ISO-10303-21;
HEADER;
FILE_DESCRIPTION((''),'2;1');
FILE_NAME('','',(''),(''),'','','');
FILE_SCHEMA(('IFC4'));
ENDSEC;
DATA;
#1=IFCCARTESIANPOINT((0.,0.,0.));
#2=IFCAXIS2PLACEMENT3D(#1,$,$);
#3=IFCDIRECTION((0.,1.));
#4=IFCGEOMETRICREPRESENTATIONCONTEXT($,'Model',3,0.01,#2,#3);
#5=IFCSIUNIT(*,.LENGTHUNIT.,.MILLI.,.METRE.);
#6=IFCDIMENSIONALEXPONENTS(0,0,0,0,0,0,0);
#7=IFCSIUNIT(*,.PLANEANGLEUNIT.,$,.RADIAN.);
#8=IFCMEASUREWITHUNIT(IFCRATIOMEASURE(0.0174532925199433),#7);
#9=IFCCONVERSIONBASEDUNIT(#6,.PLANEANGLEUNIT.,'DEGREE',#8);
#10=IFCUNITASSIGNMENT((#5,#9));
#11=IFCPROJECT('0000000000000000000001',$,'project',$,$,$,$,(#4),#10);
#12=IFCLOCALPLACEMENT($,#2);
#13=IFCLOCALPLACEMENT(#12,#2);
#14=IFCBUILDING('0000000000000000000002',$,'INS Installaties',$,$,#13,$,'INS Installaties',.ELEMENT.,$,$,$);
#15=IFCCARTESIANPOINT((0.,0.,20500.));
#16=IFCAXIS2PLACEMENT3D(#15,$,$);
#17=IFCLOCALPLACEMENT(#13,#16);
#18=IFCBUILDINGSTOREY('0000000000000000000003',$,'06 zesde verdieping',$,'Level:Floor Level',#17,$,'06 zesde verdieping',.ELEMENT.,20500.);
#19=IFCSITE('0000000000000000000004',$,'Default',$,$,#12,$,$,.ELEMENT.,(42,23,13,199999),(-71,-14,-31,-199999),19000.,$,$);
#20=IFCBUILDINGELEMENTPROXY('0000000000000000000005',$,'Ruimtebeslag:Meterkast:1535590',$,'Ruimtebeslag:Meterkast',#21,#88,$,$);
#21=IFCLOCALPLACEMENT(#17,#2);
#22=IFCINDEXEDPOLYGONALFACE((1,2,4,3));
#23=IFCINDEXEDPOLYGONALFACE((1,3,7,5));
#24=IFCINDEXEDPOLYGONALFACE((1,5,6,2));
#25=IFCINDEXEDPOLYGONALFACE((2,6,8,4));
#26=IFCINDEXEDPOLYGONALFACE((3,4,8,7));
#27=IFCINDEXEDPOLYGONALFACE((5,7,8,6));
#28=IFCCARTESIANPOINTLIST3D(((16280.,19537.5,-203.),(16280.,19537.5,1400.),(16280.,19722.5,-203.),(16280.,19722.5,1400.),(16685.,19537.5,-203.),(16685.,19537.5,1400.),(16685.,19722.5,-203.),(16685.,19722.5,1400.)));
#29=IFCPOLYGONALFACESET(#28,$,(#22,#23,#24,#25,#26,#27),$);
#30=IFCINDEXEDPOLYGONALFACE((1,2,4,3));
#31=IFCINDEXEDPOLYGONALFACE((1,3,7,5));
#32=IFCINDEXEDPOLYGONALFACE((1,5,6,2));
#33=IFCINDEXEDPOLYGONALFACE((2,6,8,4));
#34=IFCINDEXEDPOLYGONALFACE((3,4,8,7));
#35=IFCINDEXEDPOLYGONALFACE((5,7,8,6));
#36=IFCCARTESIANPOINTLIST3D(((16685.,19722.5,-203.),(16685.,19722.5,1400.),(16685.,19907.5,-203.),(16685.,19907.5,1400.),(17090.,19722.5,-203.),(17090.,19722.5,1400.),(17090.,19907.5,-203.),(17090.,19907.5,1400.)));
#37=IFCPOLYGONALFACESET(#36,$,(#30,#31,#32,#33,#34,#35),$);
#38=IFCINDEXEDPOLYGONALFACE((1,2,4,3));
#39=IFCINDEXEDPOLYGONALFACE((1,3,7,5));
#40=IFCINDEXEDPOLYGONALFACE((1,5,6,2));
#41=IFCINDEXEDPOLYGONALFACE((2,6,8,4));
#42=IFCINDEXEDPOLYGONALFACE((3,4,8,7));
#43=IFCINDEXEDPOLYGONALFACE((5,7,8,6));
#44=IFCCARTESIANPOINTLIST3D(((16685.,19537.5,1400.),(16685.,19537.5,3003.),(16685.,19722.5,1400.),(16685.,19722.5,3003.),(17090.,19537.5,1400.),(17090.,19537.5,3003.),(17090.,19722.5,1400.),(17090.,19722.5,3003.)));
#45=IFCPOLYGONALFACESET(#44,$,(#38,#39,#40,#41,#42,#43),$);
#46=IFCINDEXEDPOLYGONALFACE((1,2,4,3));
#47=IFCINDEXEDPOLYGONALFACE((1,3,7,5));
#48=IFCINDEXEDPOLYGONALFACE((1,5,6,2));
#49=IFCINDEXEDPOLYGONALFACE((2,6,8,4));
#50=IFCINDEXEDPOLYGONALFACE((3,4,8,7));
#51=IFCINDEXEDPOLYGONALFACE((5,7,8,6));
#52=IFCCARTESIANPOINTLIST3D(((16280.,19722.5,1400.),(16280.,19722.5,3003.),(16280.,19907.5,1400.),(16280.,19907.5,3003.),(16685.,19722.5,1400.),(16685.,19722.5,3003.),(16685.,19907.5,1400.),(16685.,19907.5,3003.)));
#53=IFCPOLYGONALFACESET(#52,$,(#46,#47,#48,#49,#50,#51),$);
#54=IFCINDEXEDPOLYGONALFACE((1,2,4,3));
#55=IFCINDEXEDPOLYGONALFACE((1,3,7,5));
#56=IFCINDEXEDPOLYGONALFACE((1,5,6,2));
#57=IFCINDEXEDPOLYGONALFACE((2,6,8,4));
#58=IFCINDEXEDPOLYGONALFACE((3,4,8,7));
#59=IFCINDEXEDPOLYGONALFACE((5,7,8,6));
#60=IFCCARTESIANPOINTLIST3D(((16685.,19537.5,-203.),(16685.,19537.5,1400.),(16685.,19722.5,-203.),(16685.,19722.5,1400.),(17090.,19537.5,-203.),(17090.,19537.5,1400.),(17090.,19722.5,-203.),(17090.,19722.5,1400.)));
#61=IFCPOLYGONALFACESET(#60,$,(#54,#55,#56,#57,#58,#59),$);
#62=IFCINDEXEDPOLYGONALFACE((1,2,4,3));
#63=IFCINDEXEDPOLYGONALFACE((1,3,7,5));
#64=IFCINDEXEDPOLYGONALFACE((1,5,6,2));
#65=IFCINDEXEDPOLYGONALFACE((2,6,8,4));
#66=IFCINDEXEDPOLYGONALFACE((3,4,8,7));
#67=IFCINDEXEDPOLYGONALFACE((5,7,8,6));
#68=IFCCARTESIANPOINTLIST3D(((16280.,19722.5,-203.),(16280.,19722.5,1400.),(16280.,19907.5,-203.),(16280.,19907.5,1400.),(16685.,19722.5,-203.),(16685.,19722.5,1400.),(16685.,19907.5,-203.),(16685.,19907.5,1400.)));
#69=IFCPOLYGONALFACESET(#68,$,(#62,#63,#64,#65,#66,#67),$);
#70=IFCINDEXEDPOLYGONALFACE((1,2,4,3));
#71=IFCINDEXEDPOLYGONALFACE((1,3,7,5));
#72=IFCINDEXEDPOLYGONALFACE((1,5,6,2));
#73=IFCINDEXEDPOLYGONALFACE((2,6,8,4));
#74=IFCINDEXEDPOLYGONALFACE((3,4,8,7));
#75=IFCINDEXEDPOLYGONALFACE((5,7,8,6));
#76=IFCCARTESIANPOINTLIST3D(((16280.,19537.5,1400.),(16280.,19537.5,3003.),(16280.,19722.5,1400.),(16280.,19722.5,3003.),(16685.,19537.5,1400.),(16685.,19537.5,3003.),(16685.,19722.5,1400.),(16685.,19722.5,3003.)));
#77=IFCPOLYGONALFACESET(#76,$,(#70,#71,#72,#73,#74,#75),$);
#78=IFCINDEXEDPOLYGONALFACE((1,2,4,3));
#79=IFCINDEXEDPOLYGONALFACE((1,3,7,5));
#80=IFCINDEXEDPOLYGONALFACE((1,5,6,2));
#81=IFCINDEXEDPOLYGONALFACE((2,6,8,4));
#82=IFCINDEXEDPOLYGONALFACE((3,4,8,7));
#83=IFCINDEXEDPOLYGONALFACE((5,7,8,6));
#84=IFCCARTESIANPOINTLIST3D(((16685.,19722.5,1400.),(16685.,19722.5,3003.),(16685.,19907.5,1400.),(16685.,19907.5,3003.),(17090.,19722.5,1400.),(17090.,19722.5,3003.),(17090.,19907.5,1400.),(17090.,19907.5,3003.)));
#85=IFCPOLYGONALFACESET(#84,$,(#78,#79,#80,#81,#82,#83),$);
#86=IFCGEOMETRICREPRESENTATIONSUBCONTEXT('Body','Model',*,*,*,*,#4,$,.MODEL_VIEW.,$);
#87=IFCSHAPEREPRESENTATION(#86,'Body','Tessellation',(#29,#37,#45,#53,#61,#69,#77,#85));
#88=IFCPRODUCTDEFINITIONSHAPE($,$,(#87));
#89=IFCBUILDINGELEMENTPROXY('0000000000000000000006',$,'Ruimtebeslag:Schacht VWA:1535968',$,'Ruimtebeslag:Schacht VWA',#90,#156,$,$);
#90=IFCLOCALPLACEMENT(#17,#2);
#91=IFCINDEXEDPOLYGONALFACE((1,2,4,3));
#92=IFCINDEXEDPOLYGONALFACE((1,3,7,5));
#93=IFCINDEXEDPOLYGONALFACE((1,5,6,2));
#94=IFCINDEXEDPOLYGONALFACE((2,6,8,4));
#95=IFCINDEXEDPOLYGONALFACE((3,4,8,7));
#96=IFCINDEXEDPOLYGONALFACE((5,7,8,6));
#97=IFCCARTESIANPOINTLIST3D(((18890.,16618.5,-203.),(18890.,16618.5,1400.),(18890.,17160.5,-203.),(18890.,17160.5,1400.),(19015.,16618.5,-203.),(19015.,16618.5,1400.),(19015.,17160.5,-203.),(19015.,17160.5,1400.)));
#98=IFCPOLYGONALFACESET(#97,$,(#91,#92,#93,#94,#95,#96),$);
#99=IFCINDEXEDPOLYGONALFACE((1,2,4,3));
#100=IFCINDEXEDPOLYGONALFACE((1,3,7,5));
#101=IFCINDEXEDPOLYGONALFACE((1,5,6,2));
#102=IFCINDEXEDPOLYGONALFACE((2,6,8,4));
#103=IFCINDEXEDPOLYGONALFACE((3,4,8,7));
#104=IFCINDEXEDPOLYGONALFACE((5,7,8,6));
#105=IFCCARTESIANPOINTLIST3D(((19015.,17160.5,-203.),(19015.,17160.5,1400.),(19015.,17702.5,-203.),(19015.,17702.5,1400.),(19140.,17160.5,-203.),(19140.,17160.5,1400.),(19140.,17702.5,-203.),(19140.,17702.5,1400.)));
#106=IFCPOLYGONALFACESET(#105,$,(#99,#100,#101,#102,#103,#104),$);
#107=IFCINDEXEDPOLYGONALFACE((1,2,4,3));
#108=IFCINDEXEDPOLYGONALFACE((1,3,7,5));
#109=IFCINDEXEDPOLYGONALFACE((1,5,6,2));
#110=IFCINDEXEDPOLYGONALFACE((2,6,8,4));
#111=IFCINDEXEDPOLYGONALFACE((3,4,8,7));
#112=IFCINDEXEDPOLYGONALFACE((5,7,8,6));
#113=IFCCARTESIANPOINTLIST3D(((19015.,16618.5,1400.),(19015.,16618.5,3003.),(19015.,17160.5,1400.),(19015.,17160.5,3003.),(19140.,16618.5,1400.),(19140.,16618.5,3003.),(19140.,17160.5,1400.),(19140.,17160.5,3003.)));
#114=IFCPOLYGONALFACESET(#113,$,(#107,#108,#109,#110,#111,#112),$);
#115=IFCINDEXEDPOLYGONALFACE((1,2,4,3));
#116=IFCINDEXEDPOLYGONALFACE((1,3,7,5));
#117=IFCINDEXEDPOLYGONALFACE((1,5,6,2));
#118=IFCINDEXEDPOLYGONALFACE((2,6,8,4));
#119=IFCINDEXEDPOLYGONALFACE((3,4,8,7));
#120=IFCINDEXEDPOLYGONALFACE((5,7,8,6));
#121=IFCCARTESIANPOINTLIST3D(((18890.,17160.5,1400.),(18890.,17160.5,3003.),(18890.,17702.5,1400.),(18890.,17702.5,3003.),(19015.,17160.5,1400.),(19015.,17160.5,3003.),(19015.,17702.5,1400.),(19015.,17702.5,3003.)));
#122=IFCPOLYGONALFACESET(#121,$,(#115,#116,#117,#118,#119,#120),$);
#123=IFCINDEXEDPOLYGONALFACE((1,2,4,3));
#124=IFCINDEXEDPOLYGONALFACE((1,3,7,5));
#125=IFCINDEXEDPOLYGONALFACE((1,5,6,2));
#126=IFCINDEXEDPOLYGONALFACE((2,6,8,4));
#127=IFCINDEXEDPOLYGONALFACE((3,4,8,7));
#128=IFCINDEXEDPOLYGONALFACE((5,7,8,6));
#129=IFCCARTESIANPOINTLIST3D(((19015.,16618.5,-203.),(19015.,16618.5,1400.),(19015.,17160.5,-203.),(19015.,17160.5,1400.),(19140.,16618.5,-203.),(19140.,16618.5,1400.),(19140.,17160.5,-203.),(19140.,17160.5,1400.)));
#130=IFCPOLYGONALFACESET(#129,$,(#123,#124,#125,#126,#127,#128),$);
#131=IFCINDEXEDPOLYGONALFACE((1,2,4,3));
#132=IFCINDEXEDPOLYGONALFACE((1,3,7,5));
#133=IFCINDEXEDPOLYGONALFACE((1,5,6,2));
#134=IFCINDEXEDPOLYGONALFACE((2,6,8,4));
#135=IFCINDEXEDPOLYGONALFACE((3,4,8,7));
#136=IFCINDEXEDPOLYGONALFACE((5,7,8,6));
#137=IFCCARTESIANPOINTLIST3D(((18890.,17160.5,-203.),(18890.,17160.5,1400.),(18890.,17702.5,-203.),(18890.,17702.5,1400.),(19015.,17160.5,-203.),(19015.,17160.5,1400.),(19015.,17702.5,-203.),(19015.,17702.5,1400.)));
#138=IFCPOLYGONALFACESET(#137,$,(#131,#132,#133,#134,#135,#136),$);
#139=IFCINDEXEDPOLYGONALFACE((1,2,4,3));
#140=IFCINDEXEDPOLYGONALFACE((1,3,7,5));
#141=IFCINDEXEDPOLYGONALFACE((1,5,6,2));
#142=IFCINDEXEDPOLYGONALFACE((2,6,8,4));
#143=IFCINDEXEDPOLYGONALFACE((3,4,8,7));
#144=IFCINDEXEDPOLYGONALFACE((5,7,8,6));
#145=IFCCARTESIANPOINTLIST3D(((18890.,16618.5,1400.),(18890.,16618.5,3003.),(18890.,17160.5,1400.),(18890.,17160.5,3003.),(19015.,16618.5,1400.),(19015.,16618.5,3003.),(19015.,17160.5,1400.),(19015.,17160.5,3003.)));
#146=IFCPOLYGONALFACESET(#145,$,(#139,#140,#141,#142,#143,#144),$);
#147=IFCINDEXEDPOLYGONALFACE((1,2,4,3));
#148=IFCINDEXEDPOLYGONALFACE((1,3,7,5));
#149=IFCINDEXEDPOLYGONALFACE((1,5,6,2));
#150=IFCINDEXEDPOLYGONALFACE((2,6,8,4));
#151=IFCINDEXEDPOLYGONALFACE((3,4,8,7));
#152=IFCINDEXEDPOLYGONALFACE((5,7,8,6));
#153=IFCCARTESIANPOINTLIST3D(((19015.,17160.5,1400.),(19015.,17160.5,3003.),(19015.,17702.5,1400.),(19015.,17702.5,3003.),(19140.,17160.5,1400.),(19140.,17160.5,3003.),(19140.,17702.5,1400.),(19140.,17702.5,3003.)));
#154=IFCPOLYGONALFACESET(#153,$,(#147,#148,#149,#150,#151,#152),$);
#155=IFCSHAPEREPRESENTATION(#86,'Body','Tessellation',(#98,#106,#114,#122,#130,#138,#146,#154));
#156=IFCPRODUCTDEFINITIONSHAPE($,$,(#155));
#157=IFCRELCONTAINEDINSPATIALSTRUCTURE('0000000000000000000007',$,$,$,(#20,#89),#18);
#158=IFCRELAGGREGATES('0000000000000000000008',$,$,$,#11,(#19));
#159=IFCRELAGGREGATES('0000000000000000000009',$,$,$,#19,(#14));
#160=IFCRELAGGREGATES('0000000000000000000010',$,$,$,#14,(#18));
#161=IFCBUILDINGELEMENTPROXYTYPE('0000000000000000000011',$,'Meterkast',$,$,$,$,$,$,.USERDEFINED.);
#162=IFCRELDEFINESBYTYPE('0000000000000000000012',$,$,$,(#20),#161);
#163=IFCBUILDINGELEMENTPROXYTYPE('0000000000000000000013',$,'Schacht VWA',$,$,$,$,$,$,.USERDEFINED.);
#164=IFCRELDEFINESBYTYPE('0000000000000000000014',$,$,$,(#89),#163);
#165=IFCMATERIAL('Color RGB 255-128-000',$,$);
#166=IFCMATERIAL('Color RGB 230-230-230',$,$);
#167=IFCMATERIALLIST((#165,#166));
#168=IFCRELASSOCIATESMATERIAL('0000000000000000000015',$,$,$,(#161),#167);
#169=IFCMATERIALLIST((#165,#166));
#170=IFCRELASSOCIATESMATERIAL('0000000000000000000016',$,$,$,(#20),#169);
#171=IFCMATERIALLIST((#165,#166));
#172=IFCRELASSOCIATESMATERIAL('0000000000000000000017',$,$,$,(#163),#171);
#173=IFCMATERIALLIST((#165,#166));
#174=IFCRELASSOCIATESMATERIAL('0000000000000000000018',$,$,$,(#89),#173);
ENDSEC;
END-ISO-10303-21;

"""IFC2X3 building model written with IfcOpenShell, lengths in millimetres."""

from ifc_helpers import new_model, entity, si_unit, converted_unit, direction, frame, frame_2d, origin, origin_2d_with_axis, place, context, subcontext, project, spatial, rectangle, extrude, source, transform, mapped, material, material_list, type_object, type_shapes, element, save


model = new_model("IFC2X3")

# Units and contexts
model_context = context("Model", 3, precision=0.01, world=origin(), true_north=direction((0.0, 1.0)))
body_context = subcontext(model_context, "Body", "Model", "MODEL_VIEW")
ifc_project = project(units=[si_unit("LENGTHUNIT", "METRE", prefix="MILLI"), converted_unit("PLANEANGLEUNIT", "DEGREE", entity("IfcRatioMeasure", 0.0174532925199433), si_unit("PLANEANGLEUNIT", "RADIAN"), dimensions=[0, 0, 0, 0, 0, 0, 0])], contexts=[model_context])

# Site, building, storey
site_placement = place(None, origin())
site = spatial("IfcSite", under=ifc_project, at=site_placement, Name="Default", CompositionType="ELEMENT", RefLatitude=(42, 23, 13, 199999), RefLongitude=(-71, -14, -31, -199999), RefElevation=19000.0)
building_placement = place(site_placement, origin())
building = spatial("IfcBuilding", under=site, at=building_placement, Name="INS Installaties", LongName="INS Installaties", CompositionType="ELEMENT")
storey_placement = place(building_placement, frame((0.0, 0.0, 20500.0)))
storey = spatial("IfcBuildingStorey", under=building, at=storey_placement, Name="06 zesde verdieping", ObjectType="Level:Floor Level", LongName="06 zesde verdieping", CompositionType="ELEMENT", Elevation=20500.0)

# Building element proxies
ifc_material_1 = material(Name="Color RGB 255-128-000")
ifc_material_2 = material(Name="Color RGB 230-230-230")
ifc_material_list_1 = material_list([ifc_material_1, ifc_material_2])
ifc_material_list_2 = material_list([ifc_material_1, ifc_material_2])
building_element_proxy_type_1 = type_object("IfcBuildingElementProxyType", Name="Meterkast", PredefinedType="USERDEFINED", material=ifc_material_list_2)
shared_shape_1 = source(origin(), body_context, "Body", "SweptSolid", [
    extrude(rectangle(XDim=185.0, YDim=405.0, at=origin_2d_with_axis()), frame((202.5, 92.5, -3203.0), z_axis=(0.0, 0.0, 1.0), x_axis=(0.0, -1.0, 0.0)), (0.0, 0.0, 1.0), 1603.0),
    extrude(rectangle(XDim=185.0, YDim=405.0, at=origin_2d_with_axis()), frame((-202.5, -92.5, -3203.0), z_axis=(0.0, 0.0, 1.0), x_axis=(0.0, 1.0, 0.0)), (0.0, 0.0, 1.0), 1603.0),
    extrude(rectangle(XDim=405.0, YDim=185.0, at=frame_2d((0.0, 0.0), x_axis=(1.0, 0.0))), frame((-202.5, 92.5, -1600.0), z_axis=(0.0, 0.0, 1.0), x_axis=(-1.0, 0.0, 0.0)), (0.0, 0.0, 1.0), 1603.0),
    extrude(rectangle(XDim=405.0, YDim=185.0, at=frame_2d((0.0, 0.0), x_axis=(1.0, 0.0))), frame((202.5, -92.5, -1600.0)), (0.0, 0.0, 1.0), 1603.0),
    extrude(rectangle(XDim=405.0, YDim=185.0, at=origin_2d_with_axis()), frame((-202.5, 92.5, -3203.0), z_axis=(0.0, 0.0, 1.0), x_axis=(-1.0, 0.0, 0.0)), (0.0, 0.0, 1.0), 1603.0),
    extrude(rectangle(XDim=405.0, YDim=185.0, at=frame_2d((0.0, 0.0), x_axis=(1.0, 0.0))), frame((202.5, -92.5, -3203.0)), (0.0, 0.0, 1.0), 1603.0),
    extrude(rectangle(XDim=185.0, YDim=405.0, at=origin_2d_with_axis()), frame((202.5, 92.5, -1600.0), z_axis=(0.0, 0.0, 1.0), x_axis=(0.0, -1.0, 0.0)), (0.0, 0.0, 1.0), 1603.0),
    extrude(rectangle(XDim=185.0, YDim=405.0, at=origin_2d_with_axis()), frame((-202.5, -92.5, -1600.0), z_axis=(0.0, 0.0, 1.0), x_axis=(0.0, 1.0, 0.0)), (0.0, 0.0, 1.0), 1603.0),
])
type_shapes(building_element_proxy_type_1, [shared_shape_1])
proxy_1_placement = place(storey_placement, frame((16685.0, 19722.5, 3000.0), z_axis=(0.0, 0.0, 1.0), x_axis=(-1.0, 0.0, 0.0)))
element("IfcBuildingElementProxy", 1, at=proxy_1_placement, inside=storey, type_object=building_element_proxy_type_1, material=ifc_material_list_1, Name="Ruimtebeslag:Meterkast:1535590", ObjectType="Ruimtebeslag:Meterkast", context=body_context, shape_type="MappedRepresentation", body=[
    mapped(shared_shape_1, transform((0.0, 0.0, 0.0), scale=1.0)),
])
ifc_material_list_3 = material_list([ifc_material_1, ifc_material_2])
ifc_material_list_4 = material_list([ifc_material_1, ifc_material_2])
building_element_proxy_type_2 = type_object("IfcBuildingElementProxyType", Name="Schacht VWA", PredefinedType="USERDEFINED", material=ifc_material_list_4)
shared_shape_2 = source(origin(), body_context, "Body", "SweptSolid", [
    extrude(rectangle(XDim=542.0, YDim=125.0, at=frame_2d((0.0, 0.0), x_axis=(1.0, 0.0))), frame((62.5, 271.0, -3203.0), z_axis=(0.0, 0.0, 1.0), x_axis=(0.0, -1.0, 0.0)), (0.0, 0.0, 1.0), 1603.0),
    extrude(rectangle(XDim=542.0, YDim=125.0, at=origin_2d_with_axis()), frame((-62.5, -271.0, -3203.0), z_axis=(0.0, 0.0, 1.0), x_axis=(0.0, 1.0, 0.0)), (0.0, 0.0, 1.0), 1603.0),
    extrude(rectangle(XDim=125.0, YDim=542.0, at=frame_2d((0.0, 0.0), x_axis=(1.0, 0.0))), frame((-62.5, 271.0, -1600.0), z_axis=(0.0, 0.0, 1.0), x_axis=(-1.0, 0.0, 0.0)), (0.0, 0.0, 1.0), 1603.0),
    extrude(rectangle(XDim=125.0, YDim=542.0, at=frame_2d((0.0, 0.0), x_axis=(1.0, 0.0))), frame((62.5, -271.0, -1600.0)), (0.0, 0.0, 1.0), 1603.0),
    extrude(rectangle(XDim=125.0, YDim=542.0, at=frame_2d((0.0, 0.0), x_axis=(1.0, 0.0))), frame((-62.5, 271.0, -3203.0), z_axis=(0.0, 0.0, 1.0), x_axis=(-1.0, 0.0, 0.0)), (0.0, 0.0, 1.0), 1603.0),
    extrude(rectangle(XDim=125.0, YDim=542.0, at=frame_2d((0.0, 0.0), x_axis=(1.0, 0.0))), frame((62.5, -271.0, -3203.0)), (0.0, 0.0, 1.0), 1603.0),
    extrude(rectangle(XDim=542.0, YDim=125.0, at=origin_2d_with_axis()), frame((62.5, 271.0, -1600.0), z_axis=(0.0, 0.0, 1.0), x_axis=(0.0, -1.0, 0.0)), (0.0, 0.0, 1.0), 1603.0),
    extrude(rectangle(XDim=542.0, YDim=125.0, at=origin_2d_with_axis()), frame((-62.5, -271.0, -1600.0), z_axis=(0.0, 0.0, 1.0), x_axis=(0.0, 1.0, 0.0)), (0.0, 0.0, 1.0), 1603.0),
])
type_shapes(building_element_proxy_type_2, [shared_shape_2])
proxy_2_placement = place(storey_placement, frame((19015.0, 17160.5, 3000.0), z_axis=(0.0, 0.0, 1.0), x_axis=(-1.0, 0.0, 0.0)))
element("IfcBuildingElementProxy", 2, at=proxy_2_placement, inside=storey, type_object=building_element_proxy_type_2, material=ifc_material_list_3, Name="Ruimtebeslag:Schacht VWA:1535968", ObjectType="Ruimtebeslag:Schacht VWA", context=body_context, shape_type="MappedRepresentation", body=[
    mapped(shared_shape_2, transform((0.0, 0.0, 0.0), scale=1.0)),
])

save(model, "model.ifc")
